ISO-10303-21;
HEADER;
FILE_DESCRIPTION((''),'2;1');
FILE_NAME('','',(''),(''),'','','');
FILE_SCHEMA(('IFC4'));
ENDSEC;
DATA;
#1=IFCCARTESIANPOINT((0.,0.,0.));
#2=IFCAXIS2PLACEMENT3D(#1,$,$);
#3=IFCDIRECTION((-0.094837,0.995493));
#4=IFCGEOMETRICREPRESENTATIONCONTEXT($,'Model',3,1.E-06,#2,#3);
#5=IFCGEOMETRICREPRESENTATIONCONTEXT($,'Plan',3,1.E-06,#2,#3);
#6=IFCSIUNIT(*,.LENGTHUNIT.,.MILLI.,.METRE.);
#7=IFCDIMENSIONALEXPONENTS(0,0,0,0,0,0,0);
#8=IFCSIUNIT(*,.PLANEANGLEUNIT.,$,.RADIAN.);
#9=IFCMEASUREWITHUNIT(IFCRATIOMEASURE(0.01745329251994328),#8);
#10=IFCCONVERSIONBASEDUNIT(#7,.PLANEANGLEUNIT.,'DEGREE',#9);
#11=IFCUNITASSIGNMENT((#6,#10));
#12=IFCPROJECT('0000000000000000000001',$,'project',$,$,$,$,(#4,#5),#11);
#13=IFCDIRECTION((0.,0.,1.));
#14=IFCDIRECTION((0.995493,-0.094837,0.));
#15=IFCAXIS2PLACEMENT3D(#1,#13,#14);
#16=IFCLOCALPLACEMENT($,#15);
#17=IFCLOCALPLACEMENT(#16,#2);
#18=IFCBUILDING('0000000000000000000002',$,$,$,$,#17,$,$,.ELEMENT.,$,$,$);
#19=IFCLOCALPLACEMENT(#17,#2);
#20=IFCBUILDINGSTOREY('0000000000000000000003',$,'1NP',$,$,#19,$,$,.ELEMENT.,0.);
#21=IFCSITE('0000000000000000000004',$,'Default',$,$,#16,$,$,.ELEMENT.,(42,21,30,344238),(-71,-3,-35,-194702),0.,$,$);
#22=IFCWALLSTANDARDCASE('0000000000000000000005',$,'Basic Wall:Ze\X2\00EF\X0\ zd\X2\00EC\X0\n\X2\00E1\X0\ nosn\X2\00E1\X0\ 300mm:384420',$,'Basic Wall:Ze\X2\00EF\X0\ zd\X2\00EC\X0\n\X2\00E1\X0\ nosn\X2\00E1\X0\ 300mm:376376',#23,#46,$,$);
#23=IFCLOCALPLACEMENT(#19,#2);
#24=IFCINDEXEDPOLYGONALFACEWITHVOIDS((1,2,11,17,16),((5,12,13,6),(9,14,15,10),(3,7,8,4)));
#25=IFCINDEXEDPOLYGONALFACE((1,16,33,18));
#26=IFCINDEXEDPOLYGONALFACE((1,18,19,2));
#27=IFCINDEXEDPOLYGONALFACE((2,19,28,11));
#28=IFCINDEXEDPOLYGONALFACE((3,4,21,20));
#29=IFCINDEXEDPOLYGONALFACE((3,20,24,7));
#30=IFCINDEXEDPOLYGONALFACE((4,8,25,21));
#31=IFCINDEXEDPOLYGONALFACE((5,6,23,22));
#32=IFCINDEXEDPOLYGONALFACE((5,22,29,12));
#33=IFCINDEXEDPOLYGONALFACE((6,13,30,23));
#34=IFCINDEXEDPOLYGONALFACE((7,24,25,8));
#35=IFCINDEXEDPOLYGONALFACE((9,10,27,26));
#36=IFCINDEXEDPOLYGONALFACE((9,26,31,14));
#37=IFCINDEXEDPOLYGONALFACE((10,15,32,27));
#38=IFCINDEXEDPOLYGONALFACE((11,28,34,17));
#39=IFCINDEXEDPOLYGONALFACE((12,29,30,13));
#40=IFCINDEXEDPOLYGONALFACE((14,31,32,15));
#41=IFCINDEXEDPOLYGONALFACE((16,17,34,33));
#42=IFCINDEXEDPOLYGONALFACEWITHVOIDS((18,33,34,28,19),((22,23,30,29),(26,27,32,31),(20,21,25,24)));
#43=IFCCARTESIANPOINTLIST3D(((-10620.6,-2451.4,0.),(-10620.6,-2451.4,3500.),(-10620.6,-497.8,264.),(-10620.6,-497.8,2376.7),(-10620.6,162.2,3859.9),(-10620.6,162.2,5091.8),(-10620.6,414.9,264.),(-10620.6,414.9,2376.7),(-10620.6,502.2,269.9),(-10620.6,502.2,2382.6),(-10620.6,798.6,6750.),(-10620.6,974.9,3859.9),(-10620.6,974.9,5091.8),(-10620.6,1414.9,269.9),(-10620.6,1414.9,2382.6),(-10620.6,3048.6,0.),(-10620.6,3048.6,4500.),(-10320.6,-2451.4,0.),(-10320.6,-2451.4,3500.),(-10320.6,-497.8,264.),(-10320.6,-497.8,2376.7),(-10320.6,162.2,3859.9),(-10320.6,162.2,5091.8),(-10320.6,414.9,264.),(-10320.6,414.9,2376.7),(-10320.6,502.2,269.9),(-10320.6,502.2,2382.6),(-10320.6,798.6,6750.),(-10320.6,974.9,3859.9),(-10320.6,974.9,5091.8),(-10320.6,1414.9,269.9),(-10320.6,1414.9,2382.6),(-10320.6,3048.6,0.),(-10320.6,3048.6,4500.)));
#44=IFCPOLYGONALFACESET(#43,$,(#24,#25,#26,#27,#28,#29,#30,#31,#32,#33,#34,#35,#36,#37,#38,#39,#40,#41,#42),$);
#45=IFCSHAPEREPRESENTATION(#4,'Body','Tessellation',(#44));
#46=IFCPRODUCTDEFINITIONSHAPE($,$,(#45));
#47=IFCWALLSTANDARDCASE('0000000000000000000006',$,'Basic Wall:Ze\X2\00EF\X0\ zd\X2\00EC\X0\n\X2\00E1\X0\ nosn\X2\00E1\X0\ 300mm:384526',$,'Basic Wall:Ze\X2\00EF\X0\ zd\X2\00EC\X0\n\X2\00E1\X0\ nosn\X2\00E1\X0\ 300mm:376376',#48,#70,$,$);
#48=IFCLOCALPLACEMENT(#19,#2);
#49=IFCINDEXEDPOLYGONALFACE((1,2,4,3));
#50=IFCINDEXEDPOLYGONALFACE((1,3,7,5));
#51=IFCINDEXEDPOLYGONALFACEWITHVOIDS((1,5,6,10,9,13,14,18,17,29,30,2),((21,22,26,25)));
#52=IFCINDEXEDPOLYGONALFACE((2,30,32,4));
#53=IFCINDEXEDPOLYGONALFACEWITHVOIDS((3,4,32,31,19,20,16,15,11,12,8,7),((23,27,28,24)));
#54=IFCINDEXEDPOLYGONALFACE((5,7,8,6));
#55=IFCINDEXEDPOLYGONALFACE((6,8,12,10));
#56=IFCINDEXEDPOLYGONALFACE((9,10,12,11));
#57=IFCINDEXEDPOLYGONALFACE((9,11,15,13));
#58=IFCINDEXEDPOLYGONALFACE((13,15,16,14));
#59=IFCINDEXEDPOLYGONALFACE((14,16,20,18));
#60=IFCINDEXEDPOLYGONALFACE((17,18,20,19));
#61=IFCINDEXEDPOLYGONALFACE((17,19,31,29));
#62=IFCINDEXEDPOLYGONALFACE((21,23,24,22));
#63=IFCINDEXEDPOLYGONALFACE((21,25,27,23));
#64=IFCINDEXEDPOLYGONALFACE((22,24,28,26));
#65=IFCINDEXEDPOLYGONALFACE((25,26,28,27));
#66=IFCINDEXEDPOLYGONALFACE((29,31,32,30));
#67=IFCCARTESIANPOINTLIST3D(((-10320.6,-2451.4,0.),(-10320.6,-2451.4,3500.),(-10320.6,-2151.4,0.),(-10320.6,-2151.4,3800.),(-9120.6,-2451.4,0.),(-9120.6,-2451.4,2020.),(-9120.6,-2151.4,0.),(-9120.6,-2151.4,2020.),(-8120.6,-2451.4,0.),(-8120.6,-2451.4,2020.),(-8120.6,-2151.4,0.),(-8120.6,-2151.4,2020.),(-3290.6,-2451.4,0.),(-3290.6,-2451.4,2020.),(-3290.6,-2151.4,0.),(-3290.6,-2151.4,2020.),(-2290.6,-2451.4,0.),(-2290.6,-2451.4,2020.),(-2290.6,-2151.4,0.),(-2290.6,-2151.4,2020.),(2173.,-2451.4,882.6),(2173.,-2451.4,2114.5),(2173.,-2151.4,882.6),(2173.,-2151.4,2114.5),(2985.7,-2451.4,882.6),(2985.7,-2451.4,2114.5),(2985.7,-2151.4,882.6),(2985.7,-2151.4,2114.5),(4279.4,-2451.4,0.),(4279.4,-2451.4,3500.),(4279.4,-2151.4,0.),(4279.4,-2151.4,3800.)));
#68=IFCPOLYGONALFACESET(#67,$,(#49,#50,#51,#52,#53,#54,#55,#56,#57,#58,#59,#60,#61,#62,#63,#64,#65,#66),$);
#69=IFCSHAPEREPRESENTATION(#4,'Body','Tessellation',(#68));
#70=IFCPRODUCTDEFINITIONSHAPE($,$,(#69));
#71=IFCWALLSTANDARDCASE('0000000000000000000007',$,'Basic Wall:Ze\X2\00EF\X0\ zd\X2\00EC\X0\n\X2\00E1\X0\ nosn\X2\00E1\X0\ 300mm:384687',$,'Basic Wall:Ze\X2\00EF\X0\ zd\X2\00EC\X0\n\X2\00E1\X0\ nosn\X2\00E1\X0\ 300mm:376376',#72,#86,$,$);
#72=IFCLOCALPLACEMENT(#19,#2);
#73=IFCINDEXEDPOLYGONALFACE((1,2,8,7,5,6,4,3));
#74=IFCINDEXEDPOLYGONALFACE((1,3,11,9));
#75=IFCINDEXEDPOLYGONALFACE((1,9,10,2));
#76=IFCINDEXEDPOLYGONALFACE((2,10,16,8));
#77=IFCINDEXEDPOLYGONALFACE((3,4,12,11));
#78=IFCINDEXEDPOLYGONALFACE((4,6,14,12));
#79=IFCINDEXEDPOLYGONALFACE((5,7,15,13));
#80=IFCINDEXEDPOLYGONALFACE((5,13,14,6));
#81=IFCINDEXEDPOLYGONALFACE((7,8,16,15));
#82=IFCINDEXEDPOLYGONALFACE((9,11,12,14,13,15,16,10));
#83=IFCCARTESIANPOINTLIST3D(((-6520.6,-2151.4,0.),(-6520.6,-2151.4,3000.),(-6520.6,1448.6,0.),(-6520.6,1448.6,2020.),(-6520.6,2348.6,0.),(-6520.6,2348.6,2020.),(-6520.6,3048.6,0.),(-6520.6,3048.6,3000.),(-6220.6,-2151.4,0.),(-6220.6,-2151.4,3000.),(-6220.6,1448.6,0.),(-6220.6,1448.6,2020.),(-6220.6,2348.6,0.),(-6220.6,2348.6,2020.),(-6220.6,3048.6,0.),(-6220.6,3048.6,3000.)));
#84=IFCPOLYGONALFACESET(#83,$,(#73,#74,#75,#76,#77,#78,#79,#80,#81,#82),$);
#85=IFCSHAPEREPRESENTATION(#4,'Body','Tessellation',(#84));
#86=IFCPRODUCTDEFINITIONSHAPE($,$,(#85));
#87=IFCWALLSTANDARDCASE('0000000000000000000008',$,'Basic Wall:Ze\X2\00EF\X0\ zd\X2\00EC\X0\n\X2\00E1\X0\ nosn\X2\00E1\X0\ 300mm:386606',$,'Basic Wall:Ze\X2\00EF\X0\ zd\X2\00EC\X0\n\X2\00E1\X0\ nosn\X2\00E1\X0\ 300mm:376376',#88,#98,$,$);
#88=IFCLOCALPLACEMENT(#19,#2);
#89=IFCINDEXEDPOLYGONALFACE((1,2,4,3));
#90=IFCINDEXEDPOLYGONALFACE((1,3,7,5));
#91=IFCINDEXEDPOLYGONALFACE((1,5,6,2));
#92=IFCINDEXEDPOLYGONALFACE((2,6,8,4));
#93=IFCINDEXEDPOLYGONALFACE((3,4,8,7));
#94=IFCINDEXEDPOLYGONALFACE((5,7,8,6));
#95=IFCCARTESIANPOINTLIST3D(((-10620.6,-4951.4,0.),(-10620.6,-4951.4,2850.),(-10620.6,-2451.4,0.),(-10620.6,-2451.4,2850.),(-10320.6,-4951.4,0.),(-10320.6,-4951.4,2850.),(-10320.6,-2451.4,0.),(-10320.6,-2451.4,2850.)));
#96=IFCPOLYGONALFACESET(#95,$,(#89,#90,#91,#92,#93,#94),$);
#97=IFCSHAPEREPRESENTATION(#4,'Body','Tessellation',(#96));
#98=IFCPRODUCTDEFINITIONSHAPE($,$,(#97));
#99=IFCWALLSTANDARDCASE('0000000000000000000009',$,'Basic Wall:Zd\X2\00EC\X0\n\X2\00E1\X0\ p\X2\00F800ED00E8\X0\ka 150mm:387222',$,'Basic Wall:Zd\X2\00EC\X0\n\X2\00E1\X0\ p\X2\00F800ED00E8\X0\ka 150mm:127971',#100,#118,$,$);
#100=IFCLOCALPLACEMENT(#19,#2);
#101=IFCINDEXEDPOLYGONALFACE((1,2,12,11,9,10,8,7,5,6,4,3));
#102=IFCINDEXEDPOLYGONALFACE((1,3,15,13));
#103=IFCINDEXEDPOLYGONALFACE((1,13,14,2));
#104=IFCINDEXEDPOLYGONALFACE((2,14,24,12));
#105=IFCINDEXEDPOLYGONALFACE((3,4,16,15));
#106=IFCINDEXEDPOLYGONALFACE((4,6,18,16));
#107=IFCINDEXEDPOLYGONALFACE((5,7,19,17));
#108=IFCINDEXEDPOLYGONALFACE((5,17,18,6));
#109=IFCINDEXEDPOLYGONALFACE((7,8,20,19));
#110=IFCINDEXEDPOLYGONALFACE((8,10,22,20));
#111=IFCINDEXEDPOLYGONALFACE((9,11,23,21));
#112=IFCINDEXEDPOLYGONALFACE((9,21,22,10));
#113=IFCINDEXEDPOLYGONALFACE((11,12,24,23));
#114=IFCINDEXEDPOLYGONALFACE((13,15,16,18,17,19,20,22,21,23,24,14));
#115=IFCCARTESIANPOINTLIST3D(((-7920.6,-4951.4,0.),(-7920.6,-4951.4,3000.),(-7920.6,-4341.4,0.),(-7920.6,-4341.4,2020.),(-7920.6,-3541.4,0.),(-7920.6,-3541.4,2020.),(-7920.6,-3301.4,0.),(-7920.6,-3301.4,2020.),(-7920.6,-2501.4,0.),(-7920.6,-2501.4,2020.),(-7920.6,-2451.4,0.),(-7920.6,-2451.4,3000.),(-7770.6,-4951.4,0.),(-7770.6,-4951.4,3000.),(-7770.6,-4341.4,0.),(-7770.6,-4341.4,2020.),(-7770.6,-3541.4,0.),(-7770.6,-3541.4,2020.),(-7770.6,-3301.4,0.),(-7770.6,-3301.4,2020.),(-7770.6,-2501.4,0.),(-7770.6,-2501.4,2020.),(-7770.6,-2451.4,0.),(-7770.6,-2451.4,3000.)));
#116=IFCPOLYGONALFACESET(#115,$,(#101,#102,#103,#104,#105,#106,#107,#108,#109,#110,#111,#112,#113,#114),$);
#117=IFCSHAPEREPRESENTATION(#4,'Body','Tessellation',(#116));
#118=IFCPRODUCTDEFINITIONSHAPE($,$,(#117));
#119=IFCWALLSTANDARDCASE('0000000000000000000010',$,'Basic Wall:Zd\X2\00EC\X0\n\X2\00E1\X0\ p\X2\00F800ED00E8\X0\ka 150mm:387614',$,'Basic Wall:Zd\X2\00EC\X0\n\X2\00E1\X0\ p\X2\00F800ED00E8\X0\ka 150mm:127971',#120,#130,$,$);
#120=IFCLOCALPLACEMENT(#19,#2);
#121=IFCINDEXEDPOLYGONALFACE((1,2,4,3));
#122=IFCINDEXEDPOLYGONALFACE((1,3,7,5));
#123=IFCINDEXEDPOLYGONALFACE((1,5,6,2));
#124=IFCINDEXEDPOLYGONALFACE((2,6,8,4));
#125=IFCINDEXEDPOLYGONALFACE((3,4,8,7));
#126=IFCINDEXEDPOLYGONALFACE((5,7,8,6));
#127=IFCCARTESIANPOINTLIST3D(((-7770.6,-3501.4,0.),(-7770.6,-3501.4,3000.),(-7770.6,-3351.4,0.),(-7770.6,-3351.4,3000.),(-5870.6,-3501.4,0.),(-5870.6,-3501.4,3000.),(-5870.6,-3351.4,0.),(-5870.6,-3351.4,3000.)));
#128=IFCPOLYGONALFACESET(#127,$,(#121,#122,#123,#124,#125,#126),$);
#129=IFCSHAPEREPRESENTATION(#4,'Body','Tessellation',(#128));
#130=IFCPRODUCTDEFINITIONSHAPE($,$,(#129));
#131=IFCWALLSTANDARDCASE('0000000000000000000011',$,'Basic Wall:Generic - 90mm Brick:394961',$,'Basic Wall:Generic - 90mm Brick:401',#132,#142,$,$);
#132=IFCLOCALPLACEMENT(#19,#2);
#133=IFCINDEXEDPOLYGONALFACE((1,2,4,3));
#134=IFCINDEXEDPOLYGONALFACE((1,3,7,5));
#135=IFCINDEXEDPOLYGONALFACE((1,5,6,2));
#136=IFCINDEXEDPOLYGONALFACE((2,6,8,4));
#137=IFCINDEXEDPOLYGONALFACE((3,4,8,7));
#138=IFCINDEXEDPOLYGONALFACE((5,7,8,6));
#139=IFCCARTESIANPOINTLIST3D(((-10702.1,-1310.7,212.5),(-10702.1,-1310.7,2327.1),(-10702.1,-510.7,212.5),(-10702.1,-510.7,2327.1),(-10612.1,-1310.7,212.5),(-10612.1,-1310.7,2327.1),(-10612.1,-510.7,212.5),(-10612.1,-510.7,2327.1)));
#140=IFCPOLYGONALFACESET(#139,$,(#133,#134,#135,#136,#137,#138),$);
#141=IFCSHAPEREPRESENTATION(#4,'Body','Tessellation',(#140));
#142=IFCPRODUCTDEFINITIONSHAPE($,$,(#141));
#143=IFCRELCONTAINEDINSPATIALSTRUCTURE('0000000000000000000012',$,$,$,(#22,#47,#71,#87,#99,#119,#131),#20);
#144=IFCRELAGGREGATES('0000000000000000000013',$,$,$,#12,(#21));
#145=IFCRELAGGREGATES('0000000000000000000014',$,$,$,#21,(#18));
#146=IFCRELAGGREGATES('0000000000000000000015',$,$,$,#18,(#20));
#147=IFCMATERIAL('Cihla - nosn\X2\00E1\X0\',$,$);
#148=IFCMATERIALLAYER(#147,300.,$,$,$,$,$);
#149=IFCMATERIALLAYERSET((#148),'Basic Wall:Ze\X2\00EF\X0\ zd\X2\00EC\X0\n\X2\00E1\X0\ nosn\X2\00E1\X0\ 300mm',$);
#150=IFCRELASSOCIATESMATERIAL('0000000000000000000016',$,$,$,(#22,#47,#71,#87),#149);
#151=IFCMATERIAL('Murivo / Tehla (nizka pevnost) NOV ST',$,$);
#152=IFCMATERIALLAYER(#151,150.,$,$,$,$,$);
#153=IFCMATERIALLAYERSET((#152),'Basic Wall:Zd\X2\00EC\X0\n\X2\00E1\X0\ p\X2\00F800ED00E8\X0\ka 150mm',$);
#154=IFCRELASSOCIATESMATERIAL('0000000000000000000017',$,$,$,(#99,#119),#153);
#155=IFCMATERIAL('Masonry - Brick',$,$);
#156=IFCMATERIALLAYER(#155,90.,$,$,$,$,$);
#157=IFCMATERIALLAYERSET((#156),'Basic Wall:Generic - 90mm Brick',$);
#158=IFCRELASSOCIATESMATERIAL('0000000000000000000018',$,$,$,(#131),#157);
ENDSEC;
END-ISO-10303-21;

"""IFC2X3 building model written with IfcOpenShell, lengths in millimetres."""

from ifc_helpers import new_model, entity, si_unit, converted_unit, direction, frame, frame_2d, origin, place, context, project, spatial, polyline, rectangle, extrude, clip, bounded_halfspace, material, layer, layer_set, layer_usage, element, save


model = new_model("IFC2X3")

# Units and contexts
model_context = context("Model", 3, precision=1e-06, world=origin(), true_north=direction((-0.094837, 0.995493)))
plan_context = context("Plan", 3, precision=1e-06, world=origin(), true_north=direction((-0.094837, 0.995493)))
ifc_project = project(units=[si_unit("LENGTHUNIT", "METRE", prefix="MILLI"), converted_unit("PLANEANGLEUNIT", "DEGREE", entity("IfcRatioMeasure", 0.01745329251994328), si_unit("PLANEANGLEUNIT", "RADIAN"), dimensions=[0, 0, 0, 0, 0, 0, 0])], contexts=[model_context, plan_context])

# Site, building, storey
site_placement = place(None, frame((0.0, 0.0, 0.0), z_axis=(0.0, 0.0, 1.0), x_axis=(0.995493, -0.094837, 0.0)))
site = spatial("IfcSite", under=ifc_project, at=site_placement, Name="Default", CompositionType="ELEMENT", RefLatitude=(42, 21, 30, 344238), RefLongitude=(-71, -3, -35, -194702), RefElevation=0.0)
building_placement = place(site_placement, origin())
building = spatial("IfcBuilding", under=site, at=building_placement, CompositionType="ELEMENT")
storey_placement = place(building_placement, origin())
storey = spatial("IfcBuildingStorey", under=building, at=storey_placement, Name="1NP", CompositionType="ELEMENT", Elevation=0.0)

# Shared definitions
wall_1_placement = place(storey_placement, frame((-7845.6, -2451.4, 0.0), z_axis=(0.0, 0.0, 1.0), x_axis=(0.0, -1.0, 0.0)))
opening_1_placement = place(wall_1_placement, frame((50.0, -75.0, 0.0)))
opening_2_placement = place(wall_1_placement, frame((1090.0, -75.0, 0.0)))
wall_2_placement = place(storey_placement, frame((-10320.6, -2301.4, 0.0)))
opening_3_placement = place(wall_2_placement, frame((1200.0, -150.0, 0.0)))

# Walls, openings
ifc_material_1 = material(Name="Cihla - nosná")
ifc_layer_1 = layer(ifc_material_1, 300.0)
ifc_layer_set_1 = layer_set([ifc_layer_1], Name="Basic Wall:Zeï zdìná nosná 300mm")
ifc_layer_usage_1 = layer_usage(ifc_layer_set_1, "AXIS2", "POSITIVE", -150.0)
wall_3_placement = place(storey_placement, frame((-10470.6, 3048.6, 0.0), z_axis=(0.0, 0.0, 1.0), x_axis=(0.0, -1.0, 0.0)))
wall_3 = element("IfcWallStandardCase", 1, at=wall_3_placement, inside=storey, material=ifc_layer_usage_1, Name="Basic Wall:Zeï zdìná nosná 300mm:384420", ObjectType="Basic Wall:Zeï zdìná nosná 300mm:376376", context=model_context, shape_type="Clipping", body=[
    clip(clip(extrude(rectangle(XDim=5500.0, YDim=300.0, at=frame_2d((2750.0, 0.0), x_axis=(-1.0, 0.0))), origin(), (0.0, 0.0, 1.0), 6750.0), bounded_halfspace(frame((2250.0, -150.0, 6750.0), z_axis=(0.707107, 0.0, 0.707107), x_axis=(0.0, 1.0, 0.0)), False, frame((2250.0, -150.0, 6750.0)), polyline([(0.0, 0.0), (3250.0, 0.0), (3250.0, 300.0), (2950.0, 300.0), (0.0, 300.0), (0.0, 0.0)]))), bounded_halfspace(frame((0.0, -150.0, 4500.0), z_axis=(-0.707107, 0.0, 0.707107), x_axis=(0.0, -1.0, 0.0)), False, frame((0.0, -150.0, 4500.0)), polyline([(0.0, 0.0), (2250.0, 0.0), (2250.0, 300.0), (0.0, 300.0), (0.0, 0.0)]))),
])
opening_4_placement = place(wall_3_placement, frame((3546.4, 150.0, 264.0)))
element("IfcOpeningElement", 2, at=opening_4_placement, cuts=wall_3, ObjectType="Opening", context=model_context, shape_type="SweptSolid", body=[
    extrude(rectangle(XDim=2112.7, YDim=912.7, at=frame_2d((1056.3, 456.3), x_axis=(-1.0, 0.0))), frame((0.0, 0.0, 0.0), z_axis=(0.0, -1.0, 0.0), x_axis=(0.0, 0.0, 1.0)), (0.0, 0.0, 1.0), 300.0),
])
opening_5_placement = place(wall_3_placement, frame((2546.4, 150.0, 269.9)))
element("IfcOpeningElement", 3, at=opening_5_placement, cuts=wall_3, ObjectType="Opening", context=model_context, shape_type="SweptSolid", body=[
    extrude(rectangle(XDim=2112.7, YDim=912.7, at=frame_2d((1056.3, 456.4), x_axis=(-1.0, 0.0))), frame((0.0, 0.0, 0.0), z_axis=(0.0, -1.0, 0.0), x_axis=(0.0, 0.0, 1.0)), (0.0, 0.0, 1.0), 300.0),
])
opening_6_placement = place(wall_3_placement, frame((2886.3, 150.0, 3859.9)))
element("IfcOpeningElement", 4, at=opening_6_placement, cuts=wall_3, ObjectType="Opening", context=model_context, shape_type="SweptSolid", body=[
    extrude(rectangle(XDim=1231.9, YDim=812.7, at=frame_2d((615.9, 406.4), x_axis=(-1.0, 0.0))), frame((0.0, 0.0, 0.0), z_axis=(0.0, -1.0, 0.0), x_axis=(0.0, 0.0, 1.0)), (0.0, 0.0, 1.0), 300.0),
])
ifc_layer_usage_2 = layer_usage(ifc_layer_set_1, "AXIS2", "POSITIVE", -150.0)
wall_2 = element("IfcWallStandardCase", 5, at=wall_2_placement, inside=storey, material=ifc_layer_usage_2, Name="Basic Wall:Zeï zdìná nosná 300mm:384526", ObjectType="Basic Wall:Zeï zdìná nosná 300mm:376376", context=model_context, shape_type="Clipping", body=[
    clip(extrude(rectangle(XDim=14600.0, YDim=300.0, at=frame_2d((7300.0, 0.0), x_axis=(-1.0, 0.0))), origin(), (0.0, 0.0, 1.0), 4000.0), bounded_halfspace(frame((0.0, -150.0, 3500.0), z_axis=(0.0, -0.707107, 0.707107), x_axis=(1.0, 0.0, 0.0)), False, frame((0.0, -150.0, 3500.0)), polyline([(0.0, 0.0), (14600.0, 0.0), (14600.0, 300.0), (10200.0, 300.0), (9900.0, 300.0), (0.0, 300.0), (0.0, 0.0)]))),
])
element("IfcOpeningElement", 6, at=opening_3_placement, cuts=wall_2, ObjectType="Opening", context=model_context, shape_type="SweptSolid", body=[
    extrude(rectangle(XDim=2020.0, YDim=1000.0, at=frame_2d((1010.0, 500.0), x_axis=(1.0, 0.0))), frame((0.0, 0.0, 0.0), z_axis=(0.0, 1.0, 0.0), x_axis=(0.0, 0.0, 1.0)), (0.0, 0.0, 1.0), 300.0),
])
opening_7_placement = place(wall_2_placement, frame((7030.0, -150.0, 0.0)))
element("IfcOpeningElement", 7, at=opening_7_placement, cuts=wall_2, ObjectType="Opening", context=model_context, shape_type="SweptSolid", body=[
    extrude(rectangle(XDim=2020.0, YDim=1000.0, at=frame_2d((1010.0, 500.0), x_axis=(1.0, 0.0))), frame((0.0, 0.0, 0.0), z_axis=(0.0, 1.0, 0.0), x_axis=(0.0, 0.0, 1.0)), (0.0, 0.0, 1.0), 300.0),
])
opening_8_placement = place(wall_2_placement, frame((13306.4, 150.0, 882.6)))
element("IfcOpeningElement", 8, at=opening_8_placement, cuts=wall_2, ObjectType="Opening", context=model_context, shape_type="SweptSolid", body=[
    extrude(rectangle(XDim=1231.9, YDim=812.7, at=frame_2d((615.9, 406.3), x_axis=(-1.0, 0.0))), frame((0.0, 0.0, 0.0), z_axis=(0.0, -1.0, 0.0), x_axis=(0.0, 0.0, 1.0)), (0.0, 0.0, 1.0), 300.0),
])

# Wall, opening
ifc_layer_usage_3 = layer_usage(ifc_layer_set_1, "AXIS2", "POSITIVE", -150.0)
wall_4_placement = place(storey_placement, frame((-6370.6, -2151.4, 0.0), z_axis=(0.0, 0.0, 1.0), x_axis=(0.0, 1.0, 0.0)))
wall_4 = element("IfcWallStandardCase", 9, at=wall_4_placement, inside=storey, material=ifc_layer_usage_3, Name="Basic Wall:Zeï zdìná nosná 300mm:384687", ObjectType="Basic Wall:Zeï zdìná nosná 300mm:376376", context=model_context, shape_type="SweptSolid", body=[
    extrude(rectangle(XDim=5200.0, YDim=300.0, at=frame_2d((2600.0, 0.0), x_axis=(-1.0, 0.0))), origin(), (0.0, 0.0, 1.0), 3000.0),
])
opening_9_placement = place(wall_4_placement, frame((3600.0, -150.0, 0.0)))
element("IfcOpeningElement", 10, at=opening_9_placement, cuts=wall_4, ObjectType="Opening", context=model_context, shape_type="SweptSolid", body=[
    extrude(rectangle(XDim=2020.0, YDim=900.0, at=frame_2d((1010.0, 450.0), x_axis=(1.0, 0.0))), frame((0.0, 0.0, 0.0), z_axis=(0.0, 1.0, 0.0), x_axis=(0.0, 0.0, 1.0)), (0.0, 0.0, 1.0), 300.0),
])

# Wall
ifc_layer_usage_4 = layer_usage(ifc_layer_set_1, "AXIS2", "NEGATIVE", 150.0)
wall_5_placement = place(storey_placement, frame((-10470.6, -4951.4, 0.0), z_axis=(0.0, 0.0, 1.0), x_axis=(0.0, 1.0, 0.0)))
element("IfcWallStandardCase", 11, at=wall_5_placement, inside=storey, material=ifc_layer_usage_4, Name="Basic Wall:Zeï zdìná nosná 300mm:386606", ObjectType="Basic Wall:Zeï zdìná nosná 300mm:376376", context=model_context, shape_type="Clipping", body=[
    clip(extrude(rectangle(XDim=2500.0, YDim=300.0, at=frame_2d((1250.0, 0.0), x_axis=(-1.0, 0.0))), origin(), (0.0, 0.0, 1.0), 3000.0), bounded_halfspace(frame((0.0, -150.0, 2850.0), z_axis=(0.0, 0.0, -1.0), x_axis=(-1.0, 0.0, 0.0)), True, frame((0.0, -150.0, 2850.0)), polyline([(0.0, 0.0), (2500.0, 0.0), (2500.0, 300.0), (0.0, 300.0), (0.0, 0.0)]))),
])

# Wall, openings
ifc_material_2 = material(Name="Murivo / Tehla (nizka pevnost) NOV ST")
ifc_layer_2 = layer(ifc_material_2, 150.0)
ifc_layer_set_2 = layer_set([ifc_layer_2], Name="Basic Wall:Zdìná pøíèka 150mm")
ifc_layer_usage_5 = layer_usage(ifc_layer_set_2, "AXIS2", "NEGATIVE", 75.0)
wall_1 = element("IfcWallStandardCase", 12, at=wall_1_placement, inside=storey, material=ifc_layer_usage_5, Name="Basic Wall:Zdìná pøíèka 150mm:387222", ObjectType="Basic Wall:Zdìná pøíèka 150mm:127971", context=model_context, shape_type="SweptSolid", body=[
    extrude(rectangle(XDim=2500.0, YDim=150.0, at=frame_2d((1250.0, 0.0), x_axis=(-1.0, 0.0))), origin(), (0.0, 0.0, 1.0), 3000.0),
])
element("IfcOpeningElement", 13, at=opening_1_placement, cuts=wall_1, ObjectType="Opening", context=model_context, shape_type="SweptSolid", body=[
    extrude(rectangle(XDim=2020.0, YDim=800.0, at=frame_2d((1010.0, 400.0), x_axis=(1.0, 0.0))), frame((0.0, 0.0, 0.0), z_axis=(0.0, 1.0, 0.0), x_axis=(0.0, 0.0, 1.0)), (0.0, 0.0, 1.0), 150.0),
])
element("IfcOpeningElement", 14, at=opening_2_placement, cuts=wall_1, ObjectType="Opening", context=model_context, shape_type="SweptSolid", body=[
    extrude(rectangle(XDim=2020.0, YDim=800.0, at=frame_2d((1010.0, 400.0), x_axis=(1.0, 0.0))), frame((0.0, 0.0, 0.0), z_axis=(0.0, 1.0, 0.0), x_axis=(0.0, 0.0, 1.0)), (0.0, 0.0, 1.0), 150.0),
])

# Walls
ifc_layer_usage_6 = layer_usage(ifc_layer_set_2, "AXIS2", "NEGATIVE", 75.0)
wall_6_placement = place(storey_placement, frame((-7770.6, -3426.4, 0.0)))
element("IfcWallStandardCase", 15, at=wall_6_placement, inside=storey, material=ifc_layer_usage_6, Name="Basic Wall:Zdìná pøíèka 150mm:387614", ObjectType="Basic Wall:Zdìná pøíèka 150mm:127971", context=model_context, shape_type="SweptSolid", body=[
    extrude(rectangle(XDim=1900.0, YDim=150.0, at=frame_2d((950.0, 0.0), x_axis=(-1.0, 0.0))), origin(), (0.0, 0.0, 1.0), 3000.0),
])
ifc_material_3 = material(Name="Masonry - Brick")
ifc_layer_3 = layer(ifc_material_3, 90.0)
ifc_layer_set_3 = layer_set([ifc_layer_3], Name="Basic Wall:Generic - 90mm Brick")
ifc_layer_usage_7 = layer_usage(ifc_layer_set_3, "AXIS2", "NEGATIVE", 45.0)
wall_7_placement = place(storey_placement, frame((-10657.1, -1310.7, 212.5), z_axis=(0.0, 0.0, 1.0), x_axis=(0.0, 1.0, 0.0)))
element("IfcWallStandardCase", 16, at=wall_7_placement, inside=storey, material=ifc_layer_usage_7, Name="Basic Wall:Generic - 90mm Brick:394961", ObjectType="Basic Wall:Generic - 90mm Brick:401", context=model_context, shape_type="SweptSolid", body=[
    extrude(rectangle(XDim=800.0, YDim=90.0, at=frame_2d((400.0, 0.0), x_axis=(-1.0, 0.0))), origin(), (0.0, 0.0, 1.0), 2114.6),
])

save(model, "model.ifc")
